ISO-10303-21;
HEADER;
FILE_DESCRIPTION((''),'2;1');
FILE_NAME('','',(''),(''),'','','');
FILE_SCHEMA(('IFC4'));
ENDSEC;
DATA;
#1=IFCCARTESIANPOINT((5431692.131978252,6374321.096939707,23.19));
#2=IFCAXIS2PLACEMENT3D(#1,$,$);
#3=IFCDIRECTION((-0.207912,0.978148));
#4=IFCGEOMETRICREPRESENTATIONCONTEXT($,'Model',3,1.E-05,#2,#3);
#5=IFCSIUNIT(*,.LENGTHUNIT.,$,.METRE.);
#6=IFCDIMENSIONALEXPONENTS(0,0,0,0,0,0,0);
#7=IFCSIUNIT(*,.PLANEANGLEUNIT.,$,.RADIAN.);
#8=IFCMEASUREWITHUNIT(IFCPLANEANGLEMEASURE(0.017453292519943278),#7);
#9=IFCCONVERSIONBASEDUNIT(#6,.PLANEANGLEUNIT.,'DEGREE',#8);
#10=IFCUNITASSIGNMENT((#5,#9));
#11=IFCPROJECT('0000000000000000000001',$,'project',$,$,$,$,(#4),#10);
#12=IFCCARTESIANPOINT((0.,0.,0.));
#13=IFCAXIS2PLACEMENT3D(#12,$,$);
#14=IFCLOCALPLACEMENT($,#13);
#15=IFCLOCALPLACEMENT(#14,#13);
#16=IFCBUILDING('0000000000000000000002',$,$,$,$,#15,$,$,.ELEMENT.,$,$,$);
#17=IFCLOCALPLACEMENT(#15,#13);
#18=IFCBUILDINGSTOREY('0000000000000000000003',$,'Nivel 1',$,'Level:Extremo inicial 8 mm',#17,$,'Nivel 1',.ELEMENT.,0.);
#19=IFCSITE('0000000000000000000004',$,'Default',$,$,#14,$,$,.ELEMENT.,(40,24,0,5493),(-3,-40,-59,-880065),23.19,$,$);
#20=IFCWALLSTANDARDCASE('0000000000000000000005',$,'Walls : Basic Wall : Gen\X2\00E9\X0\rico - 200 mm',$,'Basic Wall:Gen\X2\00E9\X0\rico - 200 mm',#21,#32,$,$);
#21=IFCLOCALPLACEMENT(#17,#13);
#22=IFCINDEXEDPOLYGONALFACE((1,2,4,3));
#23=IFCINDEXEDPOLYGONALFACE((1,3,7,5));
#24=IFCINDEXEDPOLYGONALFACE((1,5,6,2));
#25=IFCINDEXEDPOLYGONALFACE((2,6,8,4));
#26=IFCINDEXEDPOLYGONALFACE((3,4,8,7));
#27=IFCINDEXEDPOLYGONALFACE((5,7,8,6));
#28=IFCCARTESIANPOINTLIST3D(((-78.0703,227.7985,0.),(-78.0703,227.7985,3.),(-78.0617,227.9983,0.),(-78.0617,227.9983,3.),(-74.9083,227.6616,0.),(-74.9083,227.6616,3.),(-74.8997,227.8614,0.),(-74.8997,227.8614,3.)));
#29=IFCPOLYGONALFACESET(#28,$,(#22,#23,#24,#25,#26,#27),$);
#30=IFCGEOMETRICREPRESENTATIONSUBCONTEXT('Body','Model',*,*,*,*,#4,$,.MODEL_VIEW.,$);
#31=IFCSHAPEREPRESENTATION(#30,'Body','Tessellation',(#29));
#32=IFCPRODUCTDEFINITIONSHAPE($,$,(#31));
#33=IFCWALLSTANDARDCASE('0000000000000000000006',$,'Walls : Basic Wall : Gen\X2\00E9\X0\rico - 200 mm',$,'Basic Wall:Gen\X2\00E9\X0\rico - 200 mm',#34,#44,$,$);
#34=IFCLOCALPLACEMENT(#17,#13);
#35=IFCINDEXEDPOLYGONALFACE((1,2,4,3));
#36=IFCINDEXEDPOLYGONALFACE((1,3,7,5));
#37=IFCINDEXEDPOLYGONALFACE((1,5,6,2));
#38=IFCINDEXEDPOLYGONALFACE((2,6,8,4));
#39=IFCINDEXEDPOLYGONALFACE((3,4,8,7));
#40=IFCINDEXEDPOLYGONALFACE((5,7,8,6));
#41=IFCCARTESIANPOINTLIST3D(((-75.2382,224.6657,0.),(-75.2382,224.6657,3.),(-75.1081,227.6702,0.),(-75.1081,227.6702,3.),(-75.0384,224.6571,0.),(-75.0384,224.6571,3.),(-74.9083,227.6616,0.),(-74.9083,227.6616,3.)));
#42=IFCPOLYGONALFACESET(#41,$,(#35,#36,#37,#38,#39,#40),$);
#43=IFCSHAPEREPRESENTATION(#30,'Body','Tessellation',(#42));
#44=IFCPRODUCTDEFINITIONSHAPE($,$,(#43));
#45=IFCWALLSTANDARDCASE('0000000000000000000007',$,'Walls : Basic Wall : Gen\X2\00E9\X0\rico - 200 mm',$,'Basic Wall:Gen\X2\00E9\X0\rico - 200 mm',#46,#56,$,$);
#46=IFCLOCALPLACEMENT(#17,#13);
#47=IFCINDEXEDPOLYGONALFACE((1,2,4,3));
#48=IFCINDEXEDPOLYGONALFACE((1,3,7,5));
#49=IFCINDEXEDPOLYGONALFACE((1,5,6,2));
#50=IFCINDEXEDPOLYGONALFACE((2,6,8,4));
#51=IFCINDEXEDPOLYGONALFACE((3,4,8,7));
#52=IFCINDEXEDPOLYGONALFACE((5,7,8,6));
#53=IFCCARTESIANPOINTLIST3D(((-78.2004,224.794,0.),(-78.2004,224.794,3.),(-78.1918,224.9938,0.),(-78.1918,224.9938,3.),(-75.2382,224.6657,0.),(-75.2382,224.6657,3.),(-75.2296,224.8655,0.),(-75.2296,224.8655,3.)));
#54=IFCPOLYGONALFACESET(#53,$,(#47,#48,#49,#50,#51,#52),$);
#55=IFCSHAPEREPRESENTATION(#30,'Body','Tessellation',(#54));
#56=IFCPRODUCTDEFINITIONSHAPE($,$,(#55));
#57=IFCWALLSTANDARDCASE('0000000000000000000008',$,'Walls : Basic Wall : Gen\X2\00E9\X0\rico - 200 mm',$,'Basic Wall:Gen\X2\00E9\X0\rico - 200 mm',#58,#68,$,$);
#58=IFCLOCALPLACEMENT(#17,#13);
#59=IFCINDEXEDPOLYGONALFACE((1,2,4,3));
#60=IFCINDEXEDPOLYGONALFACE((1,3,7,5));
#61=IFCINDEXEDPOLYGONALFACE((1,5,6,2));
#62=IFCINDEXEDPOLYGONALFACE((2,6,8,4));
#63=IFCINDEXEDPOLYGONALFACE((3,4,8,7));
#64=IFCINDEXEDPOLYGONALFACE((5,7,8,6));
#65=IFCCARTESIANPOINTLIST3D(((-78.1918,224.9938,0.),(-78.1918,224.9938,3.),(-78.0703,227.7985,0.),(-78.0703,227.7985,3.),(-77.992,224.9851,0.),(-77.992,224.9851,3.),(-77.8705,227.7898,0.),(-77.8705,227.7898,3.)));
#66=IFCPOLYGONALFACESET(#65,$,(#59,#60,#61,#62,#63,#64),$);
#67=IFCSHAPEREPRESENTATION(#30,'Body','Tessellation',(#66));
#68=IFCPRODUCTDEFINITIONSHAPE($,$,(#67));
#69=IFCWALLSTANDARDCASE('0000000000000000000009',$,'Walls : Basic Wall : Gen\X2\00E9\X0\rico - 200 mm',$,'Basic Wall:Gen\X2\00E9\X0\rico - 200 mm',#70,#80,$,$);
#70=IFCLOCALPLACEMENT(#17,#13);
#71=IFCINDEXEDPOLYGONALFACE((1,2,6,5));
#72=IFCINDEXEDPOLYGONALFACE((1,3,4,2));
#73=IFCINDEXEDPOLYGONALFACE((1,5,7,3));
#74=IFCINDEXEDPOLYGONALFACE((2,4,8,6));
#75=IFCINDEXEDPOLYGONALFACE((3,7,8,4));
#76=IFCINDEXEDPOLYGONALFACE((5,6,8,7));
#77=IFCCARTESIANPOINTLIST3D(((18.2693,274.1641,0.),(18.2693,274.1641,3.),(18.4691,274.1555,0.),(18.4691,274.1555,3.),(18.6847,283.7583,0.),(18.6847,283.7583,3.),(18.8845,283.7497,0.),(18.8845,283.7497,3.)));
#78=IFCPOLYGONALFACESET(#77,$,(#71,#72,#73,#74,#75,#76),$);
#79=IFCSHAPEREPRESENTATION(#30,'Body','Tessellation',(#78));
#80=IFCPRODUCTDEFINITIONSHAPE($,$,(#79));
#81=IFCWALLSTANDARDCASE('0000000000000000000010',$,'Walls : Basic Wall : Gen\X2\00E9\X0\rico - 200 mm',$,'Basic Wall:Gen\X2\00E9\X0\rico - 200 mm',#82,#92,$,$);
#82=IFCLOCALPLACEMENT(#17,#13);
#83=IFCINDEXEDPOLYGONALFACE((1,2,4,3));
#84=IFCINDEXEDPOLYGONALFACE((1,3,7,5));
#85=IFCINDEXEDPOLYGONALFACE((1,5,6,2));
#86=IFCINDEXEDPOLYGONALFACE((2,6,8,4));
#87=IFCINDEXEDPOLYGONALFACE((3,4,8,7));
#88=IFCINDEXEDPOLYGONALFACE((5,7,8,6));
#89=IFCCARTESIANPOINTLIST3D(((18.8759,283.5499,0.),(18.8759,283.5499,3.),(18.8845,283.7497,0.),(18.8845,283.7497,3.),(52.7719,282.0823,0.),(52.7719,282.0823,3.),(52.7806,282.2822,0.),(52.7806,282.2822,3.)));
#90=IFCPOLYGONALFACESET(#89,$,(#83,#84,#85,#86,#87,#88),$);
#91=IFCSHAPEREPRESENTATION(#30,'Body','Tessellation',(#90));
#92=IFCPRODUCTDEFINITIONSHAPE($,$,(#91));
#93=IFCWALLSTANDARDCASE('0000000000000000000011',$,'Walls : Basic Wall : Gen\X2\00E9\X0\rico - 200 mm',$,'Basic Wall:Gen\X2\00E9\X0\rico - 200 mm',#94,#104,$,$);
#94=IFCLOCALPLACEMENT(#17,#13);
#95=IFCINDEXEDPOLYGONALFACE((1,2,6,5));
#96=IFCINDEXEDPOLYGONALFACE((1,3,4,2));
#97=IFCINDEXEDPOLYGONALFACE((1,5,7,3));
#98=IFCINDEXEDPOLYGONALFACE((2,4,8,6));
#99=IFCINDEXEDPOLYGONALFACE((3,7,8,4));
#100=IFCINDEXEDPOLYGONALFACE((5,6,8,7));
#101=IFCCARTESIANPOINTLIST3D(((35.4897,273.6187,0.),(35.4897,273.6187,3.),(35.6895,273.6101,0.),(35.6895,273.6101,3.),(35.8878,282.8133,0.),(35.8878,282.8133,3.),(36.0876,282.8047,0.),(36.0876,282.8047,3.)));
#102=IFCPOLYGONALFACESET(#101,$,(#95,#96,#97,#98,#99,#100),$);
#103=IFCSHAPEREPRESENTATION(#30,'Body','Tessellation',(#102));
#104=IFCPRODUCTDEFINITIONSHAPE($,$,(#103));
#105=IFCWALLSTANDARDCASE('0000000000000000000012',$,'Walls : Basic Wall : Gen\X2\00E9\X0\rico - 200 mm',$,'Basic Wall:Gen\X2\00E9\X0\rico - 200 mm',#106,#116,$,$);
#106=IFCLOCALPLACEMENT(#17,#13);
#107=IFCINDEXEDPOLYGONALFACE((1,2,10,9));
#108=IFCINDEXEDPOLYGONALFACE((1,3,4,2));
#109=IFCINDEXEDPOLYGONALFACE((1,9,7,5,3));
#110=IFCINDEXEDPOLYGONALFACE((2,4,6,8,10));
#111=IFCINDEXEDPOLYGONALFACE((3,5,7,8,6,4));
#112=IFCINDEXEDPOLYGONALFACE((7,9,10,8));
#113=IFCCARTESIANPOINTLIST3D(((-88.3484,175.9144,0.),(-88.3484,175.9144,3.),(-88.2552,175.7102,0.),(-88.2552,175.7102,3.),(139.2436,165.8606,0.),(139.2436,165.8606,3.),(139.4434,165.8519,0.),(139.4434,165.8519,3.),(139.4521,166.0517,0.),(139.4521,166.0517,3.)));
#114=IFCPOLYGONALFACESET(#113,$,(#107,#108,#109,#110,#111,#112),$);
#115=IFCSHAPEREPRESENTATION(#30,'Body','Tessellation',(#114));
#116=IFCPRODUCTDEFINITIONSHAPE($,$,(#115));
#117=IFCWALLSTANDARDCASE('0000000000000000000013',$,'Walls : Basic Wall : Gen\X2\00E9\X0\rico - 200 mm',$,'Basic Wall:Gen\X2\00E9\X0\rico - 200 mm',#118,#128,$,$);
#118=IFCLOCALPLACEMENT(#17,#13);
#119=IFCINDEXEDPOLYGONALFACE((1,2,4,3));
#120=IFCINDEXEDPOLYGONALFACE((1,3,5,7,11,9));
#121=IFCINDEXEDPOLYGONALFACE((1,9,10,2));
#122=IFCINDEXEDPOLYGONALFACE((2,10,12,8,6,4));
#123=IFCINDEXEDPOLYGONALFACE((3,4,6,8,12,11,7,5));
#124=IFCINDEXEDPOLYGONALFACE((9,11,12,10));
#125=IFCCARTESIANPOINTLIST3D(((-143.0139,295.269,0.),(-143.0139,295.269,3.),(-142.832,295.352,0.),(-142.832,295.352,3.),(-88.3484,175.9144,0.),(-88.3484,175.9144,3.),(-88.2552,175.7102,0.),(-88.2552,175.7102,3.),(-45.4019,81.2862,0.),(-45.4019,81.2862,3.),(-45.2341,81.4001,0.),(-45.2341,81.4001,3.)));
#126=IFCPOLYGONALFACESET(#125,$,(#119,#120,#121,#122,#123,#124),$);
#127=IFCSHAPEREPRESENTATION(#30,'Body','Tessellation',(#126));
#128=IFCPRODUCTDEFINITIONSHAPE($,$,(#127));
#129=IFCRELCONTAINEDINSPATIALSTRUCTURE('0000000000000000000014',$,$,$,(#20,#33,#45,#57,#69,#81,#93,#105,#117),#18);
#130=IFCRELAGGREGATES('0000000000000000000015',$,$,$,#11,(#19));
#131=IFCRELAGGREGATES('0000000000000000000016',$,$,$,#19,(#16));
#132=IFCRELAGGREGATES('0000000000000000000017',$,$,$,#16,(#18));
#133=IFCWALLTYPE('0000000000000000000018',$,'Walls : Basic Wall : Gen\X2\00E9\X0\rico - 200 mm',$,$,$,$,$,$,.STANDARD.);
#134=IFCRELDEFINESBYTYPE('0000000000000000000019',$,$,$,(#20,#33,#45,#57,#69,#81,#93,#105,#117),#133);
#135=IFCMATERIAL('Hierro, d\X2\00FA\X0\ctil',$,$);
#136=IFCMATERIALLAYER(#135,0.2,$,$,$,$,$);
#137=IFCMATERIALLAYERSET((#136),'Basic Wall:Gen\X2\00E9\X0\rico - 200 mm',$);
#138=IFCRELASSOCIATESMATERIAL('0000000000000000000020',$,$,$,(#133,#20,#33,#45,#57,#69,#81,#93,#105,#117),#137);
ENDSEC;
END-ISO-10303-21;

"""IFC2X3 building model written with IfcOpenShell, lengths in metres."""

from ifc_helpers import new_model, entity, si_unit, converted_unit, direction, frame, frame_2d, origin, place, context, subcontext, project, spatial, polyline, rectangle, outline, extrude, material, layer, layer_set, layer_usage, type_object, element, save


model = new_model("IFC2X3")

# Units and contexts
model_context = context("Model", 3, precision=1e-05, world=frame((5431692.131978252, 6374321.096939707, 23.19)), true_north=direction((-0.207912, 0.978148)))
body_context = subcontext(model_context, "Body", "Model", "MODEL_VIEW")
ifc_project = project(units=[si_unit("LENGTHUNIT", "METRE"), converted_unit("PLANEANGLEUNIT", "DEGREE", entity("IfcPlaneAngleMeasure", 0.017453292519943278), si_unit("PLANEANGLEUNIT", "RADIAN"), dimensions=[0, 0, 0, 0, 0, 0, 0])], contexts=[model_context])

# Site, building, storey
site_placement = place(None, origin())
site = spatial("IfcSite", under=ifc_project, at=site_placement, Name="Default", CompositionType="ELEMENT", RefLatitude=(40, 24, 0, 5493), RefLongitude=(-3, -40, -59, -880065), RefElevation=23.19)
building_placement = place(site_placement, origin())
building = spatial("IfcBuilding", under=site, at=building_placement, CompositionType="ELEMENT")
storey_placement = place(building_placement, origin())
storey = spatial("IfcBuildingStorey", under=building, at=storey_placement, Name="Nivel 1", ObjectType="Level:Extremo inicial 8 mm", LongName="Nivel 1", CompositionType="ELEMENT", Elevation=0.0)

# Walls
ifc_material_1 = material(Name="Hierro, dúctil")
ifc_layer_1 = layer(ifc_material_1, 0.2)
ifc_layer_set_1 = layer_set([ifc_layer_1], Name="Basic Wall:Genérico - 200 mm")
ifc_layer_usage_1 = layer_usage(ifc_layer_set_1, "AXIS2", "NEGATIVE", 0.1)
wall_type = type_object("IfcWallType", Name="Walls : Basic Wall : Genérico - 200 mm", PredefinedType="STANDARD", material=ifc_layer_set_1)
wall_1_placement = place(storey_placement, frame((-78.066, 227.8984, 0.0), z_axis=(0.0, 0.0, 1.0), x_axis=(0.999064, -0.043255, 0.0)))
element("IfcWallStandardCase", 1, at=wall_1_placement, inside=storey, type_object=wall_type, material=ifc_layer_usage_1, Name="Walls : Basic Wall : Genérico - 200 mm", ObjectType="Basic Wall:Genérico - 200 mm", context=body_context, shape_type="SweptSolid", body=[
    extrude(rectangle(XDim=3.165, YDim=0.2, at=frame_2d((1.5825, 0.0), x_axis=(-1.0, 0.0))), origin(), (0.0, 0.0, 1.0), 3.0),
])
ifc_layer_usage_2 = layer_usage(ifc_layer_set_1, "AXIS2", "NEGATIVE", 0.1)
wall_2_placement = place(storey_placement, frame((-75.0082, 227.6659, 0.0), z_axis=(0.0, 0.0, 1.0), x_axis=(-0.043255, -0.999064, 0.0)))
element("IfcWallStandardCase", 2, at=wall_2_placement, inside=storey, type_object=wall_type, material=ifc_layer_usage_2, Name="Walls : Basic Wall : Genérico - 200 mm", ObjectType="Basic Wall:Genérico - 200 mm", context=body_context, shape_type="SweptSolid", body=[
    extrude(rectangle(XDim=3.0073, YDim=0.2, at=frame_2d((1.5037, 0.0), x_axis=(-1.0, 0.0))), origin(), (0.0, 0.0, 1.0), 3.0),
])
ifc_layer_usage_3 = layer_usage(ifc_layer_set_1, "AXIS2", "NEGATIVE", 0.1)
wall_3_placement = place(storey_placement, frame((-75.2339, 224.7656, 0.0), z_axis=(0.0, 0.0, 1.0), x_axis=(-0.999064, 0.043255, 0.0)))
element("IfcWallStandardCase", 3, at=wall_3_placement, inside=storey, type_object=wall_type, material=ifc_layer_usage_3, Name="Walls : Basic Wall : Genérico - 200 mm", ObjectType="Basic Wall:Genérico - 200 mm", context=body_context, shape_type="SweptSolid", body=[
    extrude(rectangle(XDim=2.965, YDim=0.2, at=frame_2d((1.4825, 0.0), x_axis=(-1.0, 0.0))), origin(), (0.0, 0.0, 1.0), 3.0),
])
ifc_layer_usage_4 = layer_usage(ifc_layer_set_1, "AXIS2", "NEGATIVE", 0.1)
wall_4_placement = place(storey_placement, frame((-78.0919, 224.9895, 0.0), z_axis=(0.0, 0.0, 1.0), x_axis=(0.043255, 0.999064, 0.0)))
element("IfcWallStandardCase", 4, at=wall_4_placement, inside=storey, type_object=wall_type, material=ifc_layer_usage_4, Name="Walls : Basic Wall : Genérico - 200 mm", ObjectType="Basic Wall:Genérico - 200 mm", context=body_context, shape_type="SweptSolid", body=[
    extrude(rectangle(XDim=2.8073, YDim=0.2, at=frame_2d((1.4037, 0.0), x_axis=(-1.0, 0.0))), origin(), (0.0, 0.0, 1.0), 3.0),
])
ifc_layer_usage_5 = layer_usage(ifc_layer_set_1, "AXIS2", "NEGATIVE", 0.1)
wall_5_placement = place(storey_placement, frame((18.3692, 274.1598, 0.0), z_axis=(0.0, 0.0, 1.0), x_axis=(0.043255, 0.999064, 0.0)))
element("IfcWallStandardCase", 5, at=wall_5_placement, inside=storey, type_object=wall_type, material=ifc_layer_usage_5, Name="Walls : Basic Wall : Genérico - 200 mm", ObjectType="Basic Wall:Genérico - 200 mm", context=body_context, shape_type="SweptSolid", body=[
    extrude(rectangle(XDim=9.6032, YDim=0.2, at=frame_2d((4.8016, 0.0), x_axis=(-1.0, 0.0))), origin(), (0.0, 0.0, 1.0), 3.0),
])
ifc_layer_usage_6 = layer_usage(ifc_layer_set_1, "AXIS2", "NEGATIVE", 0.1)
wall_6_placement = place(storey_placement, frame((18.8802, 283.6498, 0.0), z_axis=(0.0, 0.0, 1.0), x_axis=(0.999064, -0.043255, 0.0)))
element("IfcWallStandardCase", 6, at=wall_6_placement, inside=storey, type_object=wall_type, material=ifc_layer_usage_6, Name="Walls : Basic Wall : Genérico - 200 mm", ObjectType="Basic Wall:Genérico - 200 mm", context=body_context, shape_type="SweptSolid", body=[
    extrude(rectangle(XDim=33.9278, YDim=0.2, at=frame_2d((16.9639, 0.0), x_axis=(-1.0, 0.0))), origin(), (0.0, 0.0, 1.0), 3.0),
])
ifc_layer_usage_7 = layer_usage(ifc_layer_set_1, "AXIS2", "NEGATIVE", 0.1)
wall_7_placement = place(storey_placement, frame((35.9877, 282.809, 0.0), z_axis=(0.0, 0.0, 1.0), x_axis=(-0.043255, -0.999064, 0.0)))
element("IfcWallStandardCase", 7, at=wall_7_placement, inside=storey, type_object=wall_type, material=ifc_layer_usage_7, Name="Walls : Basic Wall : Genérico - 200 mm", ObjectType="Basic Wall:Genérico - 200 mm", context=body_context, shape_type="SweptSolid", body=[
    extrude(rectangle(XDim=9.2032, YDim=0.2, at=frame_2d((4.6016, 0.0), x_axis=(-1.0, 0.0))), origin(), (0.0, 0.0, 1.0), 3.0),
])
ifc_layer_usage_8 = layer_usage(ifc_layer_set_1, "AXIS2", "NEGATIVE", 0.1)
wall_8_placement = place(storey_placement, frame((-88.3527, 175.8145, 0.0), z_axis=(0.0, 0.0, 1.0), x_axis=(0.999064, -0.043255, 0.0)))
element("IfcWallStandardCase", 8, at=wall_8_placement, inside=storey, type_object=wall_type, material=ifc_layer_usage_8, Name="Walls : Basic Wall : Genérico - 200 mm", ObjectType="Basic Wall:Genérico - 200 mm", context=body_context, shape_type="SweptSolid", body=[
    extrude(outline(polyline([(228.0138, -0.1), (228.0138, 0.1), (0.0, 0.1), (0.1019, -0.1), (227.8138, -0.1), (228.0138, -0.1)])), origin(), (0.0, 0.0, 1.0), 3.0),
])
ifc_layer_usage_9 = layer_usage(ifc_layer_set_1, "AXIS2", "NEGATIVE", 0.1)
wall_9_placement = place(storey_placement, frame((-142.9229, 295.3105, 0.0), z_axis=(0.0, 0.0, 1.0), x_axis=(0.415026, -0.90981, 0.0)))
element("IfcWallStandardCase", 9, at=wall_9_placement, inside=storey, type_object=wall_type, material=ifc_layer_usage_9, Name="Walls : Basic Wall : Genérico - 200 mm", ObjectType="Basic Wall:Genérico - 200 mm", context=body_context, shape_type="SweptSolid", body=[
    extrude(outline(polyline([(235.1951, -0.1), (235.1611, 0.1), (131.5021, 0.1), (131.2776, 0.1), (0.0, 0.1), (0.0, -0.1), (235.1951, -0.1)])), origin(), (0.0, 0.0, 1.0), 3.0),
])

save(model, "model.ifc")
